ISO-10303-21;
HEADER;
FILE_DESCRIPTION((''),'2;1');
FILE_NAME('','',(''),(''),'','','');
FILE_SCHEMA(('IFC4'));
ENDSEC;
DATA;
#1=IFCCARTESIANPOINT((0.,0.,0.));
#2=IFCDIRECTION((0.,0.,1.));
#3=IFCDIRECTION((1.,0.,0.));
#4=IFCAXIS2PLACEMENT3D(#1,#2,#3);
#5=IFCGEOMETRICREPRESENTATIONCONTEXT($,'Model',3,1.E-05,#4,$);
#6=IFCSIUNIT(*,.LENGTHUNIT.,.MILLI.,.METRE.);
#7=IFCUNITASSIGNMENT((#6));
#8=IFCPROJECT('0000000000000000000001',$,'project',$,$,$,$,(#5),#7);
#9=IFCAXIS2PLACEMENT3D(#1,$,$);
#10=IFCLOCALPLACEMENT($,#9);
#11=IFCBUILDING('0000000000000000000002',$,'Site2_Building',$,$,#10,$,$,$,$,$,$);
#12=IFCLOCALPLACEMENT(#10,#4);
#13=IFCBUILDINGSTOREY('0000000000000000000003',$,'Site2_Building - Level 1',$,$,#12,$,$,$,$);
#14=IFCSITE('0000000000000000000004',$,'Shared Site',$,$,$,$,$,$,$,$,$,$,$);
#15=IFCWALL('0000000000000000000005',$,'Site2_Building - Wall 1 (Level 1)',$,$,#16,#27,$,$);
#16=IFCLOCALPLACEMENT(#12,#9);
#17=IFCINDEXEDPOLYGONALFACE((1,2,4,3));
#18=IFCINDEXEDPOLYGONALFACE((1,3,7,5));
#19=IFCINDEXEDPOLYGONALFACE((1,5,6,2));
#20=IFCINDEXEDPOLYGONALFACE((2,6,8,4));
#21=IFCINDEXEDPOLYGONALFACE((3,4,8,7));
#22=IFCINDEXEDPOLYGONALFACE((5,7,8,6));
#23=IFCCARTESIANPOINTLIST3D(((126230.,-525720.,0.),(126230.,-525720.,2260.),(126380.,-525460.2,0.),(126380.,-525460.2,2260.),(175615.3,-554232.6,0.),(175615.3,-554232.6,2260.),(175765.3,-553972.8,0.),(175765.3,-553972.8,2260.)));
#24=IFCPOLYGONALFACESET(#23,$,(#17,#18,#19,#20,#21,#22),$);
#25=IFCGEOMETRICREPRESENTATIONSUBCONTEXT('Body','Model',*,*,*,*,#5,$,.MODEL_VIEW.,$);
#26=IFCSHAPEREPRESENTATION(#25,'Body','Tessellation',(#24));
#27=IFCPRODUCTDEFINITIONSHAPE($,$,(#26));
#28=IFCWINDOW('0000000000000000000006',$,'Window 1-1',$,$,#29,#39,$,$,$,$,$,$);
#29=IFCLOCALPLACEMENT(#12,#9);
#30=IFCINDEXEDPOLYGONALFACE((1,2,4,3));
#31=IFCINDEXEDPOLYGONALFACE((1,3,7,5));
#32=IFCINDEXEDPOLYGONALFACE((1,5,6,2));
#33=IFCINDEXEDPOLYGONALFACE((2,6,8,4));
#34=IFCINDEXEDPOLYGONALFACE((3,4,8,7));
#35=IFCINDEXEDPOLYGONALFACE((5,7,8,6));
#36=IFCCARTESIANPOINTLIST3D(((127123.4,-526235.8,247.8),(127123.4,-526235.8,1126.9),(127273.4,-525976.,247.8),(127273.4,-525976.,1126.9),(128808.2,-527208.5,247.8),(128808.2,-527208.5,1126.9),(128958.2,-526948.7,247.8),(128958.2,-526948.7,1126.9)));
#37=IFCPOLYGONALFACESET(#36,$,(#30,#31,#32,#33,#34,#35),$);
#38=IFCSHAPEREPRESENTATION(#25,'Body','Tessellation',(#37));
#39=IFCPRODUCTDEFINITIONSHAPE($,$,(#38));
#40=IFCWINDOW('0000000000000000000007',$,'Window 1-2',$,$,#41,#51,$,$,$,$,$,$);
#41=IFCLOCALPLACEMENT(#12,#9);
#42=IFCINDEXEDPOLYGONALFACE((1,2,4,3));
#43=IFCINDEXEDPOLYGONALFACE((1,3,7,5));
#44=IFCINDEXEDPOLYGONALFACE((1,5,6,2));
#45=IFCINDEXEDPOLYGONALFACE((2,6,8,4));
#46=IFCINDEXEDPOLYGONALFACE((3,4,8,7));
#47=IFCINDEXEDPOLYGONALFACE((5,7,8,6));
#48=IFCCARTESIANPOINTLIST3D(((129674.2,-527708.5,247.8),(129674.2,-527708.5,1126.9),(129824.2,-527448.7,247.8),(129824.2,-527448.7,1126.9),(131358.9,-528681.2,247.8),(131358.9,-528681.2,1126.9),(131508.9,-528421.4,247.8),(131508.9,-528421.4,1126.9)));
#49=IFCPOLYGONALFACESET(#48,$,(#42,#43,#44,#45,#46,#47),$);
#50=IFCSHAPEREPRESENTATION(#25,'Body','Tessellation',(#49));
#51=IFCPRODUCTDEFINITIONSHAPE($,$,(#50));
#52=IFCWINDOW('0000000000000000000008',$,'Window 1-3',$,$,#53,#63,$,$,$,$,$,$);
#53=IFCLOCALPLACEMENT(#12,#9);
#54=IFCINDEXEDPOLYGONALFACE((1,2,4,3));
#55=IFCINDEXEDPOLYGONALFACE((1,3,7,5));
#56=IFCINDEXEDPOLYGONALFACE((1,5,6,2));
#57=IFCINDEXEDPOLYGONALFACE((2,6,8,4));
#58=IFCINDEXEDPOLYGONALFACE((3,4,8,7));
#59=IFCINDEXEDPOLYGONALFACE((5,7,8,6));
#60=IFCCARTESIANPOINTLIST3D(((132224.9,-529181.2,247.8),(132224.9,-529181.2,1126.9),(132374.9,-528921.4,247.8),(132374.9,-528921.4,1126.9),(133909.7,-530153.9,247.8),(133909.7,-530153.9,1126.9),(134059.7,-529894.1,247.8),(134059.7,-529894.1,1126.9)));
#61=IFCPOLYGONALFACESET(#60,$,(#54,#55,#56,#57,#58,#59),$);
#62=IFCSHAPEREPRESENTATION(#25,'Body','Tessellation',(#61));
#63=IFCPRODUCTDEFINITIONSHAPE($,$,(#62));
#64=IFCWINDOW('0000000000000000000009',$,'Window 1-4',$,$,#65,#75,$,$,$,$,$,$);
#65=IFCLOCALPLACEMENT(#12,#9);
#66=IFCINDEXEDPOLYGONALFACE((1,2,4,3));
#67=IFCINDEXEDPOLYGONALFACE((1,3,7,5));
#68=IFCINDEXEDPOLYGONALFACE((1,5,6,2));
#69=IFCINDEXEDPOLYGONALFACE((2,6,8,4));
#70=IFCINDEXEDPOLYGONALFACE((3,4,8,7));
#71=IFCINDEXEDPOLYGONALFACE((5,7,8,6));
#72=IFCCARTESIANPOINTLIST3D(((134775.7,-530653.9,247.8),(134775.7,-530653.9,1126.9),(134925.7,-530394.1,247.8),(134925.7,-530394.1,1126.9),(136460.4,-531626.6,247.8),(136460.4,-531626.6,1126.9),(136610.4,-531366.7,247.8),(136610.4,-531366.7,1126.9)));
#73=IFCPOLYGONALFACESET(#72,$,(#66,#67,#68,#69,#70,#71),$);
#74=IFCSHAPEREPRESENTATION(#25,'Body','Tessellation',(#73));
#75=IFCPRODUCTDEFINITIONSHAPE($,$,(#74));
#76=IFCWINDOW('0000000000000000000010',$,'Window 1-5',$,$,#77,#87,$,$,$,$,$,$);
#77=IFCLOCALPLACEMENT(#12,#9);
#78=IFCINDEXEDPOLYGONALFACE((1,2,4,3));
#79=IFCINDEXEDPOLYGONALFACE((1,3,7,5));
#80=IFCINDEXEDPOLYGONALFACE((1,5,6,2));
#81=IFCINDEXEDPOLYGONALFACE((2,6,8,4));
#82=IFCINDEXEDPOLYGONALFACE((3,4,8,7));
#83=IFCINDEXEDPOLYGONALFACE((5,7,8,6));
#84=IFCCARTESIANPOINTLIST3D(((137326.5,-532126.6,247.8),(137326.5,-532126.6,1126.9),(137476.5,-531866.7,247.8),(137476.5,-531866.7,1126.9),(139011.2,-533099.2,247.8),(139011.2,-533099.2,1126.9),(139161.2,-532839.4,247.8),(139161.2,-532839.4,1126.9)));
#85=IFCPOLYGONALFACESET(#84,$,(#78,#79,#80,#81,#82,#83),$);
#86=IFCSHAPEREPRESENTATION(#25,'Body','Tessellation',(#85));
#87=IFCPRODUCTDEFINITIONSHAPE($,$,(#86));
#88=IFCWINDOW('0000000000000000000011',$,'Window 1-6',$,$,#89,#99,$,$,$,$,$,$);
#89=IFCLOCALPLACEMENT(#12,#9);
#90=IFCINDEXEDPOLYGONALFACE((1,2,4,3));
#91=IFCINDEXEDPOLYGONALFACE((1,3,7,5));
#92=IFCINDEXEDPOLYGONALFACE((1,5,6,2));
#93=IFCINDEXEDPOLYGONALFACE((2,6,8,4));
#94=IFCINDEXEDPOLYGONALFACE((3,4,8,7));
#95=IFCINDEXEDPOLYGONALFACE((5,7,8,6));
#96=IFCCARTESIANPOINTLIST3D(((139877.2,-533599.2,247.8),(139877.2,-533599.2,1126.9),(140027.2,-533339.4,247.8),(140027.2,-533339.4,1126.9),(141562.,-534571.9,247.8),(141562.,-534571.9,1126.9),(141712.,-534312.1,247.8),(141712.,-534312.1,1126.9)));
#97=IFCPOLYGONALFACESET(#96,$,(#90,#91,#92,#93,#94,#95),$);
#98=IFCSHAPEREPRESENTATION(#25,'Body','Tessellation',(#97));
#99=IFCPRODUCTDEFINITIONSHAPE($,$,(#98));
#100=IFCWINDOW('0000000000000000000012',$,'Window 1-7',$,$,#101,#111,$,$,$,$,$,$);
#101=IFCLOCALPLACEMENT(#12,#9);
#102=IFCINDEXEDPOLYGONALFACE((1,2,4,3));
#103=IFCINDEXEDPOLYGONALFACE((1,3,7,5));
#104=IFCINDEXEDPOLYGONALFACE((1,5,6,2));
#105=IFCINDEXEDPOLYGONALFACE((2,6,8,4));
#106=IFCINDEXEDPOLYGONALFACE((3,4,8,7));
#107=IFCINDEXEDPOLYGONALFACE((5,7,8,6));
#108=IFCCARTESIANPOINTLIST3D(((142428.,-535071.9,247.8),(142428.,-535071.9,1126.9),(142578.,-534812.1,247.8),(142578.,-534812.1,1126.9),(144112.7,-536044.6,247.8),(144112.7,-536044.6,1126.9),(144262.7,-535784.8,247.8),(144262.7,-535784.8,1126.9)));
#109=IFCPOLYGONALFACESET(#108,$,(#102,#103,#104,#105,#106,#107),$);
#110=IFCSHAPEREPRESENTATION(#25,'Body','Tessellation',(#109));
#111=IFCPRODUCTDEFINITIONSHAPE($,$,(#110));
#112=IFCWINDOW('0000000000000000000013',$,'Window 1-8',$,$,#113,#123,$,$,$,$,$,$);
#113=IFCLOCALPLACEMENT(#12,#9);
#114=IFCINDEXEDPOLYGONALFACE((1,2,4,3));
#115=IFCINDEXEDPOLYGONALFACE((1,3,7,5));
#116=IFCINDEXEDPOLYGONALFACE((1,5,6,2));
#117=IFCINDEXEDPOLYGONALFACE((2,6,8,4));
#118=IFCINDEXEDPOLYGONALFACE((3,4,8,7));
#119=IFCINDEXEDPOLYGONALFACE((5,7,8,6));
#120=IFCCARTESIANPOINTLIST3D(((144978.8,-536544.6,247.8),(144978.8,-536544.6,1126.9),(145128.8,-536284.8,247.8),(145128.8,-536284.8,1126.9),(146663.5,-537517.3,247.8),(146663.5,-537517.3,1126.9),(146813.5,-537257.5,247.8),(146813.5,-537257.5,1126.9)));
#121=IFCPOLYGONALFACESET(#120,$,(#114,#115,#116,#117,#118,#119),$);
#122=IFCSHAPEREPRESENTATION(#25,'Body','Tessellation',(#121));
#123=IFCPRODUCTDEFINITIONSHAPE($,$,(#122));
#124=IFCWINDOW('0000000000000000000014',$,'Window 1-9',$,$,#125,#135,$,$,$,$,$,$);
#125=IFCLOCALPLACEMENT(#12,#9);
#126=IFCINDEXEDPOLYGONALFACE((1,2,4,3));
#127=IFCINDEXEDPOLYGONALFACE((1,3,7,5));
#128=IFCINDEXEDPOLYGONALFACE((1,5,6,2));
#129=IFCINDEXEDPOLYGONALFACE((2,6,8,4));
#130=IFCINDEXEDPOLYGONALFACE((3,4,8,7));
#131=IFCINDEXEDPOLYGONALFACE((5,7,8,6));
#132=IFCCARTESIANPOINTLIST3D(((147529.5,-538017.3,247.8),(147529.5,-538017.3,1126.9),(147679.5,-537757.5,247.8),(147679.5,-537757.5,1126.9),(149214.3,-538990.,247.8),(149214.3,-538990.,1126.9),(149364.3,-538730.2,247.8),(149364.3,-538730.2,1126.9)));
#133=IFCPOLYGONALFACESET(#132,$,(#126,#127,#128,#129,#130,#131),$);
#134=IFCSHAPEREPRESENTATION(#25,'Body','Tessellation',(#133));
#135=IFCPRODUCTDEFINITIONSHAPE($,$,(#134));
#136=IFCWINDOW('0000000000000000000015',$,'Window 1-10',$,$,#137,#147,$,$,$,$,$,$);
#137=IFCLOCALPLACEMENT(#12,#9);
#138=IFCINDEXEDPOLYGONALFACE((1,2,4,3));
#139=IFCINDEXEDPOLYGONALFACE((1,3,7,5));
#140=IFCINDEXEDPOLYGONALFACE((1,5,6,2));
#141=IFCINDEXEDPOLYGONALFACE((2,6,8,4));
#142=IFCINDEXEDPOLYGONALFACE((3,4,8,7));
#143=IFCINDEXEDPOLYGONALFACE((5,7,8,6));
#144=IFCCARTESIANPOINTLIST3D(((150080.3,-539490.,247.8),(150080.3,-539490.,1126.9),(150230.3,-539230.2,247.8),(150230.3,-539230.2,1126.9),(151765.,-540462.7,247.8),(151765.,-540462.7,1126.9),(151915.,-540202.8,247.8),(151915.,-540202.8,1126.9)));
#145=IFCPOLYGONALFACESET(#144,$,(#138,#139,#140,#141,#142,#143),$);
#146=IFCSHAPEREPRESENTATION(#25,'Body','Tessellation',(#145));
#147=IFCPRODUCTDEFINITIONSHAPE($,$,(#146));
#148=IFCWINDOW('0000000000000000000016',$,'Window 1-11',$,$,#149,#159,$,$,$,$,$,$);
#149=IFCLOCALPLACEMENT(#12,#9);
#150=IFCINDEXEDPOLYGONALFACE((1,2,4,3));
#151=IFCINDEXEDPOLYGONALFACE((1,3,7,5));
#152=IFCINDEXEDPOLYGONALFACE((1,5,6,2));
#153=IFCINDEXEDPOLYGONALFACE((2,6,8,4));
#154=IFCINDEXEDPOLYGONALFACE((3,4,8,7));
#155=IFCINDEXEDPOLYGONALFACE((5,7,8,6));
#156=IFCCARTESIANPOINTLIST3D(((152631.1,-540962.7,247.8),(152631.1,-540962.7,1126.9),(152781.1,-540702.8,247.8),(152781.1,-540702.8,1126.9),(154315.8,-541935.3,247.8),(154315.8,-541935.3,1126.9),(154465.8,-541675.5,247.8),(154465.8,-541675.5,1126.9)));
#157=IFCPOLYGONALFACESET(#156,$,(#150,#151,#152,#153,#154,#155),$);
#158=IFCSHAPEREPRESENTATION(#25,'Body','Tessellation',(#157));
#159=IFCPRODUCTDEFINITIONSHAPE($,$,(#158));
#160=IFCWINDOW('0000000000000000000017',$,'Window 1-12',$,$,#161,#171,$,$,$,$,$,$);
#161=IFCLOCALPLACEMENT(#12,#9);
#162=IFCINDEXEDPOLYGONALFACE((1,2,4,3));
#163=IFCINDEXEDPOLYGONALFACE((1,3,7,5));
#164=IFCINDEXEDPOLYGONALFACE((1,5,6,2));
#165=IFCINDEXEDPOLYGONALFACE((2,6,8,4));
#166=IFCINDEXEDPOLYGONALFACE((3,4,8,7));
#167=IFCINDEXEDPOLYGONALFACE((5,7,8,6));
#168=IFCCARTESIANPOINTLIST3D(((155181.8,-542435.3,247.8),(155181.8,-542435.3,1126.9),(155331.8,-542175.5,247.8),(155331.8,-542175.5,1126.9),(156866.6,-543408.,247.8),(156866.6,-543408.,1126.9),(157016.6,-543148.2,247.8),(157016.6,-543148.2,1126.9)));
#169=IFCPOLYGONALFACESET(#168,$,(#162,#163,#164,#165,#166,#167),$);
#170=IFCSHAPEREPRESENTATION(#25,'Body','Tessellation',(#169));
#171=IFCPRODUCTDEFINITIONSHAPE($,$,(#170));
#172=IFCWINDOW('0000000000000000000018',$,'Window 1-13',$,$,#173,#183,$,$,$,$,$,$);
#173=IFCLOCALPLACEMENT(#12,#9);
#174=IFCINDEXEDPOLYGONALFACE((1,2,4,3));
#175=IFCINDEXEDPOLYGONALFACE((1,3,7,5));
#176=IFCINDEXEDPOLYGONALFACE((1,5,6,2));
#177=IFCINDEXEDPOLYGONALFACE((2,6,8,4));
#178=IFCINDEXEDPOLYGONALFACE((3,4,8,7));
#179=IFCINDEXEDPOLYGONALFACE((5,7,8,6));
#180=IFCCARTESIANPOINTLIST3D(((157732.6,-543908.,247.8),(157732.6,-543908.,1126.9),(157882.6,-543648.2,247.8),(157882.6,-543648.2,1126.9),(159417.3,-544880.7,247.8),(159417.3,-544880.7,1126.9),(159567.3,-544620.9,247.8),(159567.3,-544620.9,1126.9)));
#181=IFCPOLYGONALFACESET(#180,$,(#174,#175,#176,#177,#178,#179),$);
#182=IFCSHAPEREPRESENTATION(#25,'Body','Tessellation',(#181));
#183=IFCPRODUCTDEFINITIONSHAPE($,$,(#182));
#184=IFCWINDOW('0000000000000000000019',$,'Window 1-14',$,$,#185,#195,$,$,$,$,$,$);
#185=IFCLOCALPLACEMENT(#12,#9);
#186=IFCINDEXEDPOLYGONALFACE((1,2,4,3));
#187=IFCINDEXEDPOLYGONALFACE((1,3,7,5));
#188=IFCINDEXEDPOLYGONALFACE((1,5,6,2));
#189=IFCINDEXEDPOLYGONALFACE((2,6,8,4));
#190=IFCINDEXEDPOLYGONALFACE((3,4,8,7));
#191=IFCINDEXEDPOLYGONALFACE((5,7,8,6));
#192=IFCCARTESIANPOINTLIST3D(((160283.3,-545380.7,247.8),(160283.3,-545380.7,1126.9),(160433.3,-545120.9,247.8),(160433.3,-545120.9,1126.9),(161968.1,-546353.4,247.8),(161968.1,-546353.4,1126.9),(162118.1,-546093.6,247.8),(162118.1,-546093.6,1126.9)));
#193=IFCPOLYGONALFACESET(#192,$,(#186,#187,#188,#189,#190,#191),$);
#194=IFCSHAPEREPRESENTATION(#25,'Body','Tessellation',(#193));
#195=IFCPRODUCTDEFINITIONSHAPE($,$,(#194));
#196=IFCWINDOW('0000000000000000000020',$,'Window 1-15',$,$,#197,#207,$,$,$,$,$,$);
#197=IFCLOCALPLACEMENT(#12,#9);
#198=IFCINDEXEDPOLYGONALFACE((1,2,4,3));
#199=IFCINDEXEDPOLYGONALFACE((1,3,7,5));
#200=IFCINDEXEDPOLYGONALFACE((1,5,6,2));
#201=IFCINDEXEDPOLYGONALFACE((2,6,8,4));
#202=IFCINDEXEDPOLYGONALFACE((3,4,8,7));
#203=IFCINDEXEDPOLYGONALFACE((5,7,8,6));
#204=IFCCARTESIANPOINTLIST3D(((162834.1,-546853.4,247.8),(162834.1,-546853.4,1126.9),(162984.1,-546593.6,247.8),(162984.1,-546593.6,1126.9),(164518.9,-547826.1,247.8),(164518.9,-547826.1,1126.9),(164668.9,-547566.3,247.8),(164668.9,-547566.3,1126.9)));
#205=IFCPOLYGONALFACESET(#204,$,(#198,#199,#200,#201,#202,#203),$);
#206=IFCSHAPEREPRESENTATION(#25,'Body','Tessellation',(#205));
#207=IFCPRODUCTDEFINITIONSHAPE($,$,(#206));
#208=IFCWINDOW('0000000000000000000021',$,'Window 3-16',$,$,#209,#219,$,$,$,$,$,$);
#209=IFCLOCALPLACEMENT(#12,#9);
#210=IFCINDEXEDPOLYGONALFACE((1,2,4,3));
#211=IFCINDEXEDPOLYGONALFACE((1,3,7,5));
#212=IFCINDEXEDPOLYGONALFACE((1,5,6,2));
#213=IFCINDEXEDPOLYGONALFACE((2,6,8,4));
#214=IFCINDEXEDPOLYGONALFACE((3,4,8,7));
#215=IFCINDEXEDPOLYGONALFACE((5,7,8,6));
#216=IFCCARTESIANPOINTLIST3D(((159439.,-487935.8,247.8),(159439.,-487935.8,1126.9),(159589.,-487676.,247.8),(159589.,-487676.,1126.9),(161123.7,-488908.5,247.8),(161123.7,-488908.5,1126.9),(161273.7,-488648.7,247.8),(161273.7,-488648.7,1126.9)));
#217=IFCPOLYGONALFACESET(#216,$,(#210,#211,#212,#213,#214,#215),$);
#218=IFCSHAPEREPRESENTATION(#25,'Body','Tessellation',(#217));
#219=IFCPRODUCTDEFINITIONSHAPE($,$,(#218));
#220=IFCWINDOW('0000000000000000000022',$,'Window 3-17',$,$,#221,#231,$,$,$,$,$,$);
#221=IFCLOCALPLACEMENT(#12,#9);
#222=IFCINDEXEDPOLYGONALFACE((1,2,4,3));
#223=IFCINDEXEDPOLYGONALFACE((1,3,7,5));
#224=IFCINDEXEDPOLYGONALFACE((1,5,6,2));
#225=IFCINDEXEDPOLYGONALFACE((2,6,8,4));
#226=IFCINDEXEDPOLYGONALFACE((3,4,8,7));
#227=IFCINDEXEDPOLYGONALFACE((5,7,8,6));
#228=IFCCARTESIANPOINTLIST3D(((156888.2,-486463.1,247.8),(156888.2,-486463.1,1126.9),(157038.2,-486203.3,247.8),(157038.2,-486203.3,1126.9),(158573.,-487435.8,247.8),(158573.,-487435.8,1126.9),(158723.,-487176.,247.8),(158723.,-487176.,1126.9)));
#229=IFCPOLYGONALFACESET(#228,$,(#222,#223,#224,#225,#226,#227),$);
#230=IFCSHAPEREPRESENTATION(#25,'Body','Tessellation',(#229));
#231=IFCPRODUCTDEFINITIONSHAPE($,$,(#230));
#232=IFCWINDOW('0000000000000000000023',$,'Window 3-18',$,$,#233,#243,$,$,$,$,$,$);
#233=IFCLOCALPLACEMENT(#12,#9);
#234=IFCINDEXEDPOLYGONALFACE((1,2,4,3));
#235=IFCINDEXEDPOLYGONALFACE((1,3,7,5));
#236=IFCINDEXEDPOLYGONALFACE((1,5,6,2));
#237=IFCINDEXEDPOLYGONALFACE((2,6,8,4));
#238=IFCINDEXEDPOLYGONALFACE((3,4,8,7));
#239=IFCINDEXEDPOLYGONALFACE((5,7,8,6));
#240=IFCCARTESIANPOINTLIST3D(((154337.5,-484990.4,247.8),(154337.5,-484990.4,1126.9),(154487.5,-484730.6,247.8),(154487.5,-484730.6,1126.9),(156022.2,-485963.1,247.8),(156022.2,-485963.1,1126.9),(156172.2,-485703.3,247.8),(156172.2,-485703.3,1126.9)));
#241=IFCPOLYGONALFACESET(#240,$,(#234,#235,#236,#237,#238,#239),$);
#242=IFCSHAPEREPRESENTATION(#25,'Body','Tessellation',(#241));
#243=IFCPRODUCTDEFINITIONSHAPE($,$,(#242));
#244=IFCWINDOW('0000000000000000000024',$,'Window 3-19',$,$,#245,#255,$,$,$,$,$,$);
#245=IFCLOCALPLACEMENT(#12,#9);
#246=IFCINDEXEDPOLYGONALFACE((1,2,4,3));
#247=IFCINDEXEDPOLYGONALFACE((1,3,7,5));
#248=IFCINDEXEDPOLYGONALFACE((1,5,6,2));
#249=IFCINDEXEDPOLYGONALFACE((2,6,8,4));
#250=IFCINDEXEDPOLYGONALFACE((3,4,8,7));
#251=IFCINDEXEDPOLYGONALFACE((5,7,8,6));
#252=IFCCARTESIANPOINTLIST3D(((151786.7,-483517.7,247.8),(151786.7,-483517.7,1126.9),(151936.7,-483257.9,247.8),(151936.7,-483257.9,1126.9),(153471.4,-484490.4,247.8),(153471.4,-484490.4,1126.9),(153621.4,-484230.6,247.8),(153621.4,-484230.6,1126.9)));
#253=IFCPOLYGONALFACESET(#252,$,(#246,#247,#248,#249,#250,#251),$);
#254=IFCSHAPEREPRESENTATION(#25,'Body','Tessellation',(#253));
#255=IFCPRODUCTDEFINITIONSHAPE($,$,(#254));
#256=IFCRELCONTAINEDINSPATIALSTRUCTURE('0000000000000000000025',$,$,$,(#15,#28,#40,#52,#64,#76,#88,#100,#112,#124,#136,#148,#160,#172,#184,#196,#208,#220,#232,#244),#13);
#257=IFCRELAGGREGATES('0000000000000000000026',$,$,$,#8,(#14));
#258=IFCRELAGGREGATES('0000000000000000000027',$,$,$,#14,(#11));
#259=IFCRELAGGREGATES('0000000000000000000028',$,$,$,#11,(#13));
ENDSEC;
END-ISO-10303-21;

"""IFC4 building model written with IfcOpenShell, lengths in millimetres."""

from ifc_helpers import new_model, si_unit, frame, origin, origin_with_axes, place, context, subcontext, project, spatial, indexed_curve, outline, extrude, element, save


model = new_model("IFC4")

# Units and contexts
model_context = context("Model", 3, precision=1e-05, world=origin_with_axes())
body_context = subcontext(model_context, "Body", "Model", "MODEL_VIEW")
ifc_project = project(units=[si_unit("LENGTHUNIT", "METRE", prefix="MILLI")], contexts=[model_context])

# Site, building, storey
site = spatial("IfcSite", under=ifc_project, Name="Shared Site")
building_placement = place(None, origin())
building = spatial("IfcBuilding", under=site, at=building_placement, Name="Site2_Building")
storey_placement = place(building_placement, origin_with_axes())
storey = spatial("IfcBuildingStorey", under=building, at=storey_placement, Name="Site2_Building - Level 1")

# Wall
wall_1_placement = place(storey_placement, frame((126230.0, -525720.0, 0.0), z_axis=(0.0, 0.0, 1.0), x_axis=(0.866025, -0.5, 0.0)))
element("IfcWall", 1, at=wall_1_placement, inside=storey, Name="Site2_Building - Wall 1 (Level 1)", context=body_context, shape_type="SweptSolid", body=[
    extrude(outline(indexed_curve([(0.0, 0.0), (0.0, 300.0), (57025.3, 300.0), (57025.3, 0.0), (0.0, 0.0)], self_intersect=False)), origin_with_axes(), (0.0, 0.0, 1.0), 2260.0),
])

# Windows
for number, where, z_axis, x_axis, name in (
    (2, (127123.4, -526235.8, 247.8), (0.0, 0.0, 1.0), (0.866025, -0.5, 0.0), "Window 1-1"),
    (3, (129674.2, -527708.5, 247.8), (0.0, 0.0, 1.0), (0.866025, -0.5, 0.0), "Window 1-2"),
    (4, (132224.9, -529181.2, 247.8), (0.0, 0.0, 1.0), (0.866025, -0.5, 0.0), "Window 1-3"),
    (5, (134775.7, -530653.9, 247.8), (0.0, 0.0, 1.0), (0.866025, -0.5, 0.0), "Window 1-4"),
    (6, (137326.5, -532126.6, 247.8), (0.0, 0.0, 1.0), (0.866025, -0.5, 0.0), "Window 1-5"),
    (7, (139877.2, -533599.2, 247.8), (0.0, 0.0, 1.0), (0.866025, -0.5, 0.0), "Window 1-6"),
    (8, (142428.0, -535071.9, 247.8), (0.0, 0.0, 1.0), (0.866025, -0.5, 0.0), "Window 1-7"),
    (9, (144978.8, -536544.6, 247.8), (0.0, 0.0, 1.0), (0.866025, -0.5, 0.0), "Window 1-8"),
    (10, (147529.5, -538017.3, 247.8), (0.0, 0.0, 1.0), (0.866025, -0.5, 0.0), "Window 1-9"),
    (11, (150080.3, -539490.0, 247.8), (0.0, 0.0, 1.0), (0.866025, -0.5, 0.0), "Window 1-10"),
    (12, (152631.1, -540962.7, 247.8), (0.0, 0.0, 1.0), (0.866025, -0.5, 0.0), "Window 1-11"),
    (13, (155181.8, -542435.3, 247.8), (0.0, 0.0, 1.0), (0.866025, -0.5, 0.0), "Window 1-12"),
    (14, (157732.6, -543908.0, 247.8), (0.0, 0.0, 1.0), (0.866025, -0.5, 0.0), "Window 1-13"),
    (15, (160283.3, -545380.7, 247.8), (0.0, 0.0, 1.0), (0.866025, -0.5, 0.0), "Window 1-14"),
    (16, (162834.1, -546853.4, 247.8), (0.0, 0.0, 1.0), (0.866025, -0.5, 0.0), "Window 1-15"),
    (17, (161273.7, -488648.7, 247.8), (0.0, 0.0, 1.0), (-0.866025, 0.5, 0.0), "Window 3-16"),
    (18, (158723.0, -487176.0, 247.8), (0.0, 0.0, 1.0), (-0.866025, 0.5, 0.0), "Window 3-17"),
    (19, (156172.2, -485703.3, 247.8), (0.0, 0.0, 1.0), (-0.866025, 0.5, 0.0), "Window 3-18"),
    (20, (153621.4, -484230.6, 247.8), (0.0, 0.0, 1.0), (-0.866025, 0.5, 0.0), "Window 3-19"),
):
    element("IfcWindow", number, at=place(storey_placement, frame(where, z_axis=z_axis, x_axis=x_axis)), inside=storey, Name=name, context=body_context, shape_type="SweptSolid", body=[
        extrude(outline(indexed_curve([(0.0, 0.0), (0.0, 300.0), (1945.4, 300.0), (1945.4, 0.0), (0.0, 0.0)], self_intersect=False)), origin_with_axes(), (0.0, 0.0, 1.0), 879.1),
    ])

save(model, "model.ifc")
